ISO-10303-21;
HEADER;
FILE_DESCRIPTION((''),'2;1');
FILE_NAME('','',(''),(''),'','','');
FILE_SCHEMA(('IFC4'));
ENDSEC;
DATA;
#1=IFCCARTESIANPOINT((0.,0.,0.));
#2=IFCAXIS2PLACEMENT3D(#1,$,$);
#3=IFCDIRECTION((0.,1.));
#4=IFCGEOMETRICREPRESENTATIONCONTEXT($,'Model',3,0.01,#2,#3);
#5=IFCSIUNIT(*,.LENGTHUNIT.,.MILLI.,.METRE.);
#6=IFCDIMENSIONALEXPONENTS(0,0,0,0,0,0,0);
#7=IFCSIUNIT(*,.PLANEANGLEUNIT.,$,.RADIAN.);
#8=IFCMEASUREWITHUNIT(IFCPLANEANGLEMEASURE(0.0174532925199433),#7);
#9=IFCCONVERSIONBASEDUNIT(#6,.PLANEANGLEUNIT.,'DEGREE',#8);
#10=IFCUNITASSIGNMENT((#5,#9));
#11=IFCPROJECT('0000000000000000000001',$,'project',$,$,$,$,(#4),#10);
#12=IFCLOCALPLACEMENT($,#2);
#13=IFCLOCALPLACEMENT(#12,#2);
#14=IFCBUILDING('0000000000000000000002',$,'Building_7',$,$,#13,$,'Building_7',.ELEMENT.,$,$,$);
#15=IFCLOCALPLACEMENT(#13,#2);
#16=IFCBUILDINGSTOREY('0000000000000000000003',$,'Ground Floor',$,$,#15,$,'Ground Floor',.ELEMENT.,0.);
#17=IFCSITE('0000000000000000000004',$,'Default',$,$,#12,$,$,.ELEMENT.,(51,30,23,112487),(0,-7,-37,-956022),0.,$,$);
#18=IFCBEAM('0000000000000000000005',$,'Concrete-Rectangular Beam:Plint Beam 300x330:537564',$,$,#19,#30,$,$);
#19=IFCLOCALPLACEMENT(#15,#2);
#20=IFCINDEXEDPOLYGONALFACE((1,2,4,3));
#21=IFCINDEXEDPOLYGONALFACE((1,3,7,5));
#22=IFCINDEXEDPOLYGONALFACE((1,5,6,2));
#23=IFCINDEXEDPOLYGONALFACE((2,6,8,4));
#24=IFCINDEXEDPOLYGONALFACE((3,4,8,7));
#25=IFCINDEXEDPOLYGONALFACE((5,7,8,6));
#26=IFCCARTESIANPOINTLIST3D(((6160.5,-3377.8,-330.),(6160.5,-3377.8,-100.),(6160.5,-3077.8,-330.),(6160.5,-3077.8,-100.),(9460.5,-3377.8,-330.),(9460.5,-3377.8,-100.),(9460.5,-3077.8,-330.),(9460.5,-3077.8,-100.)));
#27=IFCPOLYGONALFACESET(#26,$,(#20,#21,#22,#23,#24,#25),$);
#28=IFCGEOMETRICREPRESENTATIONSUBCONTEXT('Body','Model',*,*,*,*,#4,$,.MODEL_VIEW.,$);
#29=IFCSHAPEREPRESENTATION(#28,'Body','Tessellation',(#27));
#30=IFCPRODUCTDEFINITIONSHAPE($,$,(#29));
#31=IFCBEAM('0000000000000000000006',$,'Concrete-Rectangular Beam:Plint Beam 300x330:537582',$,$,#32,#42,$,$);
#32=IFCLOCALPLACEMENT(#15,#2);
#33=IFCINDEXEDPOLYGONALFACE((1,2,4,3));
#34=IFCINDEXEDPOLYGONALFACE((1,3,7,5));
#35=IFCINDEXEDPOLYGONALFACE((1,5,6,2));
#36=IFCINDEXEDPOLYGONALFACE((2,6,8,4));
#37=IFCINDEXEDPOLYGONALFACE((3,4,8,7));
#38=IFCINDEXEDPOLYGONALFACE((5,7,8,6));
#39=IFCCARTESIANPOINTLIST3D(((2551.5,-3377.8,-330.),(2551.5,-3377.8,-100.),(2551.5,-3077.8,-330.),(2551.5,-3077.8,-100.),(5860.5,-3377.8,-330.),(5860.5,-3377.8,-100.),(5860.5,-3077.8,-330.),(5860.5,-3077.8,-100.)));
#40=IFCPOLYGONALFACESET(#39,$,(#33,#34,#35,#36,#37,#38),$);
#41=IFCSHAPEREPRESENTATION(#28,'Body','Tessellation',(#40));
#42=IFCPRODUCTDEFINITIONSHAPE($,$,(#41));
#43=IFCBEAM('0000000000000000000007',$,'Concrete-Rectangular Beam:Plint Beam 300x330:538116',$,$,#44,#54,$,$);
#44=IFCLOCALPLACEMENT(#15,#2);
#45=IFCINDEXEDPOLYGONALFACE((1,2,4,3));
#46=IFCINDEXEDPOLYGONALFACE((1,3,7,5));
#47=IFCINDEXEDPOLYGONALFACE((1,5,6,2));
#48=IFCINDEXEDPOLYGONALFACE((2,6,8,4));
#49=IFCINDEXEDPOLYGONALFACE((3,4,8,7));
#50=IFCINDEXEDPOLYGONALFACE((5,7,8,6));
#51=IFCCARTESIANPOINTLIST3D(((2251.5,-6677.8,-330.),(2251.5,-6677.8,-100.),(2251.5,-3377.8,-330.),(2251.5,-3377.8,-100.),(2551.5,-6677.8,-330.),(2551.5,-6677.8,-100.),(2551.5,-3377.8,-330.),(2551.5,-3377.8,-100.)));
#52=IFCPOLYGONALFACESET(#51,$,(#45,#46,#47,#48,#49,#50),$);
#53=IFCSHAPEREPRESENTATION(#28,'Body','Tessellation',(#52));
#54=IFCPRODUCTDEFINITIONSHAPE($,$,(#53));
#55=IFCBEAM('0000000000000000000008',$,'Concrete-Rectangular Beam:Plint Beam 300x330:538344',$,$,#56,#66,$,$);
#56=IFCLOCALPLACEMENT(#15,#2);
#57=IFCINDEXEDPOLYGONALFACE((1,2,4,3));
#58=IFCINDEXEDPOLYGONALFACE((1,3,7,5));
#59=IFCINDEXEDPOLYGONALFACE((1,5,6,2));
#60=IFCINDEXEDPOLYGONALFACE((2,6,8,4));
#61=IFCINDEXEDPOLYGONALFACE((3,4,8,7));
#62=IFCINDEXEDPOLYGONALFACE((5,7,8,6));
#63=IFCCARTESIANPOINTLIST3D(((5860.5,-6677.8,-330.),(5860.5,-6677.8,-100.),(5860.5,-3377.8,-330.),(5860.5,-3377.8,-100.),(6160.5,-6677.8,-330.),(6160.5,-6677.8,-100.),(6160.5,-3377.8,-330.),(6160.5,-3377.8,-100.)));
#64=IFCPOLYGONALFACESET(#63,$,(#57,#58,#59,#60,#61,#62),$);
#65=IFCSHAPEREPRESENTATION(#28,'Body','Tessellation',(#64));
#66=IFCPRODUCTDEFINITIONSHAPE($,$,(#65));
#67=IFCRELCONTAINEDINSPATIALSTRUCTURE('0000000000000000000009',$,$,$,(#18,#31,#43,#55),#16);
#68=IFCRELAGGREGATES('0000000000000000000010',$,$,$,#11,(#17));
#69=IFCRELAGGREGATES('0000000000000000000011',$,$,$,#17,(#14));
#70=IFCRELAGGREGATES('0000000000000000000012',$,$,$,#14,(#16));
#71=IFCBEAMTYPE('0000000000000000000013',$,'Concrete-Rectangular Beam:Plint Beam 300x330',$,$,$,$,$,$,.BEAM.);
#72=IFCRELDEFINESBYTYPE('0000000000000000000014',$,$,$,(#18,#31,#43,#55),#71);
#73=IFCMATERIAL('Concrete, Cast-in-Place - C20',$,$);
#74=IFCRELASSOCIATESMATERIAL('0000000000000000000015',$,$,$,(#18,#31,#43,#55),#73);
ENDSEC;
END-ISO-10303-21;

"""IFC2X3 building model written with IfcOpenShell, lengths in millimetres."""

from ifc_helpers import new_model, entity, si_unit, converted_unit, direction, frame, frame_2d, origin, place, context, subcontext, project, spatial, rectangle, extrude, material, type_object, element, save


model = new_model("IFC2X3")

# Units and contexts
model_context = context("Model", 3, precision=0.01, world=origin(), true_north=direction((0.0, 1.0)))
body_context = subcontext(model_context, "Body", "Model", "MODEL_VIEW")
ifc_project = project(units=[si_unit("LENGTHUNIT", "METRE", prefix="MILLI"), converted_unit("PLANEANGLEUNIT", "DEGREE", entity("IfcPlaneAngleMeasure", 0.0174532925199433), si_unit("PLANEANGLEUNIT", "RADIAN"), dimensions=[0, 0, 0, 0, 0, 0, 0])], contexts=[model_context])

# Site, building, storey
site_placement = place(None, origin())
site = spatial("IfcSite", under=ifc_project, at=site_placement, Name="Default", CompositionType="ELEMENT", RefLatitude=(51, 30, 23, 112487), RefLongitude=(0, -7, -37, -956022), RefElevation=0.0)
building_placement = place(site_placement, origin())
building = spatial("IfcBuilding", under=site, at=building_placement, Name="Building_7", LongName="Building_7", CompositionType="ELEMENT")
storey_placement = place(building_placement, origin())
storey = spatial("IfcBuildingStorey", under=building, at=storey_placement, Name="Ground Floor", LongName="Ground Floor", CompositionType="ELEMENT", Elevation=0.0)

# Beams
ifc_material_1 = material(Name="Concrete, Cast-in-Place - C20")
beam_type = type_object("IfcBeamType", Name="Concrete-Rectangular Beam:Plint Beam 300x330", PredefinedType="BEAM")
beam_1_placement = place(storey_placement, frame((9610.5, -3227.8, 0.0), z_axis=(0.0, 0.0, 1.0), x_axis=(-1.0, 0.0, 0.0)))
element("IfcBeam", 1, at=beam_1_placement, inside=storey, type_object=beam_type, material=ifc_material_1, Name="Concrete-Rectangular Beam:Plint Beam 300x330:537564", context=body_context, shape_type="SweptSolid", body=[
    extrude(rectangle(XDim=230.0, YDim=300.0, at=frame_2d((0.0, 0.0), x_axis=(1.0, 0.0))), frame((150.0, 0.0, -215.0), z_axis=(1.0, 0.0, 0.0), x_axis=(0.0, 0.0, -1.0)), (0.0, 0.0, 1.0), 3300.0),
])
beam_2_placement = place(storey_placement, frame((6010.5, -3227.8, 0.0), z_axis=(0.0, 0.0, 1.0), x_axis=(-1.0, 0.0, 0.0)))
element("IfcBeam", 2, at=beam_2_placement, inside=storey, type_object=beam_type, material=ifc_material_1, Name="Concrete-Rectangular Beam:Plint Beam 300x330:537582", context=body_context, shape_type="SweptSolid", body=[
    extrude(rectangle(XDim=230.0, YDim=300.0, at=frame_2d((0.0, 0.0), x_axis=(1.0, 0.0))), frame((150.0, 0.0, -215.0), z_axis=(1.0, 0.0, 0.0), x_axis=(0.0, 0.0, -1.0)), (0.0, 0.0, 1.0), 3308.9),
])
beam_3_placement = place(storey_placement, frame((2401.5, -3227.8, 0.0), z_axis=(0.0, 0.0, 1.0), x_axis=(0.0, -1.0, 0.0)))
element("IfcBeam", 3, at=beam_3_placement, inside=storey, type_object=beam_type, material=ifc_material_1, Name="Concrete-Rectangular Beam:Plint Beam 300x330:538116", context=body_context, shape_type="SweptSolid", body=[
    extrude(rectangle(XDim=230.0, YDim=300.0, at=frame_2d((0.0, 0.0), x_axis=(1.0, 0.0))), frame((150.0, 0.0, -215.0), z_axis=(1.0, 0.0, 0.0), x_axis=(0.0, 0.0, -1.0)), (0.0, 0.0, 1.0), 3300.0),
])
beam_4_placement = place(storey_placement, frame((6010.5, -3227.8, 0.0), z_axis=(0.0, 0.0, 1.0), x_axis=(0.0, -1.0, 0.0)))
element("IfcBeam", 4, at=beam_4_placement, inside=storey, type_object=beam_type, material=ifc_material_1, Name="Concrete-Rectangular Beam:Plint Beam 300x330:538344", context=body_context, shape_type="SweptSolid", body=[
    extrude(rectangle(XDim=230.0, YDim=300.0, at=frame_2d((0.0, 0.0), x_axis=(1.0, 0.0))), frame((150.0, 0.0, -215.0), z_axis=(1.0, 0.0, 0.0), x_axis=(0.0, 0.0, -1.0)), (0.0, 0.0, 1.0), 3300.0),
])

save(model, "model.ifc")
